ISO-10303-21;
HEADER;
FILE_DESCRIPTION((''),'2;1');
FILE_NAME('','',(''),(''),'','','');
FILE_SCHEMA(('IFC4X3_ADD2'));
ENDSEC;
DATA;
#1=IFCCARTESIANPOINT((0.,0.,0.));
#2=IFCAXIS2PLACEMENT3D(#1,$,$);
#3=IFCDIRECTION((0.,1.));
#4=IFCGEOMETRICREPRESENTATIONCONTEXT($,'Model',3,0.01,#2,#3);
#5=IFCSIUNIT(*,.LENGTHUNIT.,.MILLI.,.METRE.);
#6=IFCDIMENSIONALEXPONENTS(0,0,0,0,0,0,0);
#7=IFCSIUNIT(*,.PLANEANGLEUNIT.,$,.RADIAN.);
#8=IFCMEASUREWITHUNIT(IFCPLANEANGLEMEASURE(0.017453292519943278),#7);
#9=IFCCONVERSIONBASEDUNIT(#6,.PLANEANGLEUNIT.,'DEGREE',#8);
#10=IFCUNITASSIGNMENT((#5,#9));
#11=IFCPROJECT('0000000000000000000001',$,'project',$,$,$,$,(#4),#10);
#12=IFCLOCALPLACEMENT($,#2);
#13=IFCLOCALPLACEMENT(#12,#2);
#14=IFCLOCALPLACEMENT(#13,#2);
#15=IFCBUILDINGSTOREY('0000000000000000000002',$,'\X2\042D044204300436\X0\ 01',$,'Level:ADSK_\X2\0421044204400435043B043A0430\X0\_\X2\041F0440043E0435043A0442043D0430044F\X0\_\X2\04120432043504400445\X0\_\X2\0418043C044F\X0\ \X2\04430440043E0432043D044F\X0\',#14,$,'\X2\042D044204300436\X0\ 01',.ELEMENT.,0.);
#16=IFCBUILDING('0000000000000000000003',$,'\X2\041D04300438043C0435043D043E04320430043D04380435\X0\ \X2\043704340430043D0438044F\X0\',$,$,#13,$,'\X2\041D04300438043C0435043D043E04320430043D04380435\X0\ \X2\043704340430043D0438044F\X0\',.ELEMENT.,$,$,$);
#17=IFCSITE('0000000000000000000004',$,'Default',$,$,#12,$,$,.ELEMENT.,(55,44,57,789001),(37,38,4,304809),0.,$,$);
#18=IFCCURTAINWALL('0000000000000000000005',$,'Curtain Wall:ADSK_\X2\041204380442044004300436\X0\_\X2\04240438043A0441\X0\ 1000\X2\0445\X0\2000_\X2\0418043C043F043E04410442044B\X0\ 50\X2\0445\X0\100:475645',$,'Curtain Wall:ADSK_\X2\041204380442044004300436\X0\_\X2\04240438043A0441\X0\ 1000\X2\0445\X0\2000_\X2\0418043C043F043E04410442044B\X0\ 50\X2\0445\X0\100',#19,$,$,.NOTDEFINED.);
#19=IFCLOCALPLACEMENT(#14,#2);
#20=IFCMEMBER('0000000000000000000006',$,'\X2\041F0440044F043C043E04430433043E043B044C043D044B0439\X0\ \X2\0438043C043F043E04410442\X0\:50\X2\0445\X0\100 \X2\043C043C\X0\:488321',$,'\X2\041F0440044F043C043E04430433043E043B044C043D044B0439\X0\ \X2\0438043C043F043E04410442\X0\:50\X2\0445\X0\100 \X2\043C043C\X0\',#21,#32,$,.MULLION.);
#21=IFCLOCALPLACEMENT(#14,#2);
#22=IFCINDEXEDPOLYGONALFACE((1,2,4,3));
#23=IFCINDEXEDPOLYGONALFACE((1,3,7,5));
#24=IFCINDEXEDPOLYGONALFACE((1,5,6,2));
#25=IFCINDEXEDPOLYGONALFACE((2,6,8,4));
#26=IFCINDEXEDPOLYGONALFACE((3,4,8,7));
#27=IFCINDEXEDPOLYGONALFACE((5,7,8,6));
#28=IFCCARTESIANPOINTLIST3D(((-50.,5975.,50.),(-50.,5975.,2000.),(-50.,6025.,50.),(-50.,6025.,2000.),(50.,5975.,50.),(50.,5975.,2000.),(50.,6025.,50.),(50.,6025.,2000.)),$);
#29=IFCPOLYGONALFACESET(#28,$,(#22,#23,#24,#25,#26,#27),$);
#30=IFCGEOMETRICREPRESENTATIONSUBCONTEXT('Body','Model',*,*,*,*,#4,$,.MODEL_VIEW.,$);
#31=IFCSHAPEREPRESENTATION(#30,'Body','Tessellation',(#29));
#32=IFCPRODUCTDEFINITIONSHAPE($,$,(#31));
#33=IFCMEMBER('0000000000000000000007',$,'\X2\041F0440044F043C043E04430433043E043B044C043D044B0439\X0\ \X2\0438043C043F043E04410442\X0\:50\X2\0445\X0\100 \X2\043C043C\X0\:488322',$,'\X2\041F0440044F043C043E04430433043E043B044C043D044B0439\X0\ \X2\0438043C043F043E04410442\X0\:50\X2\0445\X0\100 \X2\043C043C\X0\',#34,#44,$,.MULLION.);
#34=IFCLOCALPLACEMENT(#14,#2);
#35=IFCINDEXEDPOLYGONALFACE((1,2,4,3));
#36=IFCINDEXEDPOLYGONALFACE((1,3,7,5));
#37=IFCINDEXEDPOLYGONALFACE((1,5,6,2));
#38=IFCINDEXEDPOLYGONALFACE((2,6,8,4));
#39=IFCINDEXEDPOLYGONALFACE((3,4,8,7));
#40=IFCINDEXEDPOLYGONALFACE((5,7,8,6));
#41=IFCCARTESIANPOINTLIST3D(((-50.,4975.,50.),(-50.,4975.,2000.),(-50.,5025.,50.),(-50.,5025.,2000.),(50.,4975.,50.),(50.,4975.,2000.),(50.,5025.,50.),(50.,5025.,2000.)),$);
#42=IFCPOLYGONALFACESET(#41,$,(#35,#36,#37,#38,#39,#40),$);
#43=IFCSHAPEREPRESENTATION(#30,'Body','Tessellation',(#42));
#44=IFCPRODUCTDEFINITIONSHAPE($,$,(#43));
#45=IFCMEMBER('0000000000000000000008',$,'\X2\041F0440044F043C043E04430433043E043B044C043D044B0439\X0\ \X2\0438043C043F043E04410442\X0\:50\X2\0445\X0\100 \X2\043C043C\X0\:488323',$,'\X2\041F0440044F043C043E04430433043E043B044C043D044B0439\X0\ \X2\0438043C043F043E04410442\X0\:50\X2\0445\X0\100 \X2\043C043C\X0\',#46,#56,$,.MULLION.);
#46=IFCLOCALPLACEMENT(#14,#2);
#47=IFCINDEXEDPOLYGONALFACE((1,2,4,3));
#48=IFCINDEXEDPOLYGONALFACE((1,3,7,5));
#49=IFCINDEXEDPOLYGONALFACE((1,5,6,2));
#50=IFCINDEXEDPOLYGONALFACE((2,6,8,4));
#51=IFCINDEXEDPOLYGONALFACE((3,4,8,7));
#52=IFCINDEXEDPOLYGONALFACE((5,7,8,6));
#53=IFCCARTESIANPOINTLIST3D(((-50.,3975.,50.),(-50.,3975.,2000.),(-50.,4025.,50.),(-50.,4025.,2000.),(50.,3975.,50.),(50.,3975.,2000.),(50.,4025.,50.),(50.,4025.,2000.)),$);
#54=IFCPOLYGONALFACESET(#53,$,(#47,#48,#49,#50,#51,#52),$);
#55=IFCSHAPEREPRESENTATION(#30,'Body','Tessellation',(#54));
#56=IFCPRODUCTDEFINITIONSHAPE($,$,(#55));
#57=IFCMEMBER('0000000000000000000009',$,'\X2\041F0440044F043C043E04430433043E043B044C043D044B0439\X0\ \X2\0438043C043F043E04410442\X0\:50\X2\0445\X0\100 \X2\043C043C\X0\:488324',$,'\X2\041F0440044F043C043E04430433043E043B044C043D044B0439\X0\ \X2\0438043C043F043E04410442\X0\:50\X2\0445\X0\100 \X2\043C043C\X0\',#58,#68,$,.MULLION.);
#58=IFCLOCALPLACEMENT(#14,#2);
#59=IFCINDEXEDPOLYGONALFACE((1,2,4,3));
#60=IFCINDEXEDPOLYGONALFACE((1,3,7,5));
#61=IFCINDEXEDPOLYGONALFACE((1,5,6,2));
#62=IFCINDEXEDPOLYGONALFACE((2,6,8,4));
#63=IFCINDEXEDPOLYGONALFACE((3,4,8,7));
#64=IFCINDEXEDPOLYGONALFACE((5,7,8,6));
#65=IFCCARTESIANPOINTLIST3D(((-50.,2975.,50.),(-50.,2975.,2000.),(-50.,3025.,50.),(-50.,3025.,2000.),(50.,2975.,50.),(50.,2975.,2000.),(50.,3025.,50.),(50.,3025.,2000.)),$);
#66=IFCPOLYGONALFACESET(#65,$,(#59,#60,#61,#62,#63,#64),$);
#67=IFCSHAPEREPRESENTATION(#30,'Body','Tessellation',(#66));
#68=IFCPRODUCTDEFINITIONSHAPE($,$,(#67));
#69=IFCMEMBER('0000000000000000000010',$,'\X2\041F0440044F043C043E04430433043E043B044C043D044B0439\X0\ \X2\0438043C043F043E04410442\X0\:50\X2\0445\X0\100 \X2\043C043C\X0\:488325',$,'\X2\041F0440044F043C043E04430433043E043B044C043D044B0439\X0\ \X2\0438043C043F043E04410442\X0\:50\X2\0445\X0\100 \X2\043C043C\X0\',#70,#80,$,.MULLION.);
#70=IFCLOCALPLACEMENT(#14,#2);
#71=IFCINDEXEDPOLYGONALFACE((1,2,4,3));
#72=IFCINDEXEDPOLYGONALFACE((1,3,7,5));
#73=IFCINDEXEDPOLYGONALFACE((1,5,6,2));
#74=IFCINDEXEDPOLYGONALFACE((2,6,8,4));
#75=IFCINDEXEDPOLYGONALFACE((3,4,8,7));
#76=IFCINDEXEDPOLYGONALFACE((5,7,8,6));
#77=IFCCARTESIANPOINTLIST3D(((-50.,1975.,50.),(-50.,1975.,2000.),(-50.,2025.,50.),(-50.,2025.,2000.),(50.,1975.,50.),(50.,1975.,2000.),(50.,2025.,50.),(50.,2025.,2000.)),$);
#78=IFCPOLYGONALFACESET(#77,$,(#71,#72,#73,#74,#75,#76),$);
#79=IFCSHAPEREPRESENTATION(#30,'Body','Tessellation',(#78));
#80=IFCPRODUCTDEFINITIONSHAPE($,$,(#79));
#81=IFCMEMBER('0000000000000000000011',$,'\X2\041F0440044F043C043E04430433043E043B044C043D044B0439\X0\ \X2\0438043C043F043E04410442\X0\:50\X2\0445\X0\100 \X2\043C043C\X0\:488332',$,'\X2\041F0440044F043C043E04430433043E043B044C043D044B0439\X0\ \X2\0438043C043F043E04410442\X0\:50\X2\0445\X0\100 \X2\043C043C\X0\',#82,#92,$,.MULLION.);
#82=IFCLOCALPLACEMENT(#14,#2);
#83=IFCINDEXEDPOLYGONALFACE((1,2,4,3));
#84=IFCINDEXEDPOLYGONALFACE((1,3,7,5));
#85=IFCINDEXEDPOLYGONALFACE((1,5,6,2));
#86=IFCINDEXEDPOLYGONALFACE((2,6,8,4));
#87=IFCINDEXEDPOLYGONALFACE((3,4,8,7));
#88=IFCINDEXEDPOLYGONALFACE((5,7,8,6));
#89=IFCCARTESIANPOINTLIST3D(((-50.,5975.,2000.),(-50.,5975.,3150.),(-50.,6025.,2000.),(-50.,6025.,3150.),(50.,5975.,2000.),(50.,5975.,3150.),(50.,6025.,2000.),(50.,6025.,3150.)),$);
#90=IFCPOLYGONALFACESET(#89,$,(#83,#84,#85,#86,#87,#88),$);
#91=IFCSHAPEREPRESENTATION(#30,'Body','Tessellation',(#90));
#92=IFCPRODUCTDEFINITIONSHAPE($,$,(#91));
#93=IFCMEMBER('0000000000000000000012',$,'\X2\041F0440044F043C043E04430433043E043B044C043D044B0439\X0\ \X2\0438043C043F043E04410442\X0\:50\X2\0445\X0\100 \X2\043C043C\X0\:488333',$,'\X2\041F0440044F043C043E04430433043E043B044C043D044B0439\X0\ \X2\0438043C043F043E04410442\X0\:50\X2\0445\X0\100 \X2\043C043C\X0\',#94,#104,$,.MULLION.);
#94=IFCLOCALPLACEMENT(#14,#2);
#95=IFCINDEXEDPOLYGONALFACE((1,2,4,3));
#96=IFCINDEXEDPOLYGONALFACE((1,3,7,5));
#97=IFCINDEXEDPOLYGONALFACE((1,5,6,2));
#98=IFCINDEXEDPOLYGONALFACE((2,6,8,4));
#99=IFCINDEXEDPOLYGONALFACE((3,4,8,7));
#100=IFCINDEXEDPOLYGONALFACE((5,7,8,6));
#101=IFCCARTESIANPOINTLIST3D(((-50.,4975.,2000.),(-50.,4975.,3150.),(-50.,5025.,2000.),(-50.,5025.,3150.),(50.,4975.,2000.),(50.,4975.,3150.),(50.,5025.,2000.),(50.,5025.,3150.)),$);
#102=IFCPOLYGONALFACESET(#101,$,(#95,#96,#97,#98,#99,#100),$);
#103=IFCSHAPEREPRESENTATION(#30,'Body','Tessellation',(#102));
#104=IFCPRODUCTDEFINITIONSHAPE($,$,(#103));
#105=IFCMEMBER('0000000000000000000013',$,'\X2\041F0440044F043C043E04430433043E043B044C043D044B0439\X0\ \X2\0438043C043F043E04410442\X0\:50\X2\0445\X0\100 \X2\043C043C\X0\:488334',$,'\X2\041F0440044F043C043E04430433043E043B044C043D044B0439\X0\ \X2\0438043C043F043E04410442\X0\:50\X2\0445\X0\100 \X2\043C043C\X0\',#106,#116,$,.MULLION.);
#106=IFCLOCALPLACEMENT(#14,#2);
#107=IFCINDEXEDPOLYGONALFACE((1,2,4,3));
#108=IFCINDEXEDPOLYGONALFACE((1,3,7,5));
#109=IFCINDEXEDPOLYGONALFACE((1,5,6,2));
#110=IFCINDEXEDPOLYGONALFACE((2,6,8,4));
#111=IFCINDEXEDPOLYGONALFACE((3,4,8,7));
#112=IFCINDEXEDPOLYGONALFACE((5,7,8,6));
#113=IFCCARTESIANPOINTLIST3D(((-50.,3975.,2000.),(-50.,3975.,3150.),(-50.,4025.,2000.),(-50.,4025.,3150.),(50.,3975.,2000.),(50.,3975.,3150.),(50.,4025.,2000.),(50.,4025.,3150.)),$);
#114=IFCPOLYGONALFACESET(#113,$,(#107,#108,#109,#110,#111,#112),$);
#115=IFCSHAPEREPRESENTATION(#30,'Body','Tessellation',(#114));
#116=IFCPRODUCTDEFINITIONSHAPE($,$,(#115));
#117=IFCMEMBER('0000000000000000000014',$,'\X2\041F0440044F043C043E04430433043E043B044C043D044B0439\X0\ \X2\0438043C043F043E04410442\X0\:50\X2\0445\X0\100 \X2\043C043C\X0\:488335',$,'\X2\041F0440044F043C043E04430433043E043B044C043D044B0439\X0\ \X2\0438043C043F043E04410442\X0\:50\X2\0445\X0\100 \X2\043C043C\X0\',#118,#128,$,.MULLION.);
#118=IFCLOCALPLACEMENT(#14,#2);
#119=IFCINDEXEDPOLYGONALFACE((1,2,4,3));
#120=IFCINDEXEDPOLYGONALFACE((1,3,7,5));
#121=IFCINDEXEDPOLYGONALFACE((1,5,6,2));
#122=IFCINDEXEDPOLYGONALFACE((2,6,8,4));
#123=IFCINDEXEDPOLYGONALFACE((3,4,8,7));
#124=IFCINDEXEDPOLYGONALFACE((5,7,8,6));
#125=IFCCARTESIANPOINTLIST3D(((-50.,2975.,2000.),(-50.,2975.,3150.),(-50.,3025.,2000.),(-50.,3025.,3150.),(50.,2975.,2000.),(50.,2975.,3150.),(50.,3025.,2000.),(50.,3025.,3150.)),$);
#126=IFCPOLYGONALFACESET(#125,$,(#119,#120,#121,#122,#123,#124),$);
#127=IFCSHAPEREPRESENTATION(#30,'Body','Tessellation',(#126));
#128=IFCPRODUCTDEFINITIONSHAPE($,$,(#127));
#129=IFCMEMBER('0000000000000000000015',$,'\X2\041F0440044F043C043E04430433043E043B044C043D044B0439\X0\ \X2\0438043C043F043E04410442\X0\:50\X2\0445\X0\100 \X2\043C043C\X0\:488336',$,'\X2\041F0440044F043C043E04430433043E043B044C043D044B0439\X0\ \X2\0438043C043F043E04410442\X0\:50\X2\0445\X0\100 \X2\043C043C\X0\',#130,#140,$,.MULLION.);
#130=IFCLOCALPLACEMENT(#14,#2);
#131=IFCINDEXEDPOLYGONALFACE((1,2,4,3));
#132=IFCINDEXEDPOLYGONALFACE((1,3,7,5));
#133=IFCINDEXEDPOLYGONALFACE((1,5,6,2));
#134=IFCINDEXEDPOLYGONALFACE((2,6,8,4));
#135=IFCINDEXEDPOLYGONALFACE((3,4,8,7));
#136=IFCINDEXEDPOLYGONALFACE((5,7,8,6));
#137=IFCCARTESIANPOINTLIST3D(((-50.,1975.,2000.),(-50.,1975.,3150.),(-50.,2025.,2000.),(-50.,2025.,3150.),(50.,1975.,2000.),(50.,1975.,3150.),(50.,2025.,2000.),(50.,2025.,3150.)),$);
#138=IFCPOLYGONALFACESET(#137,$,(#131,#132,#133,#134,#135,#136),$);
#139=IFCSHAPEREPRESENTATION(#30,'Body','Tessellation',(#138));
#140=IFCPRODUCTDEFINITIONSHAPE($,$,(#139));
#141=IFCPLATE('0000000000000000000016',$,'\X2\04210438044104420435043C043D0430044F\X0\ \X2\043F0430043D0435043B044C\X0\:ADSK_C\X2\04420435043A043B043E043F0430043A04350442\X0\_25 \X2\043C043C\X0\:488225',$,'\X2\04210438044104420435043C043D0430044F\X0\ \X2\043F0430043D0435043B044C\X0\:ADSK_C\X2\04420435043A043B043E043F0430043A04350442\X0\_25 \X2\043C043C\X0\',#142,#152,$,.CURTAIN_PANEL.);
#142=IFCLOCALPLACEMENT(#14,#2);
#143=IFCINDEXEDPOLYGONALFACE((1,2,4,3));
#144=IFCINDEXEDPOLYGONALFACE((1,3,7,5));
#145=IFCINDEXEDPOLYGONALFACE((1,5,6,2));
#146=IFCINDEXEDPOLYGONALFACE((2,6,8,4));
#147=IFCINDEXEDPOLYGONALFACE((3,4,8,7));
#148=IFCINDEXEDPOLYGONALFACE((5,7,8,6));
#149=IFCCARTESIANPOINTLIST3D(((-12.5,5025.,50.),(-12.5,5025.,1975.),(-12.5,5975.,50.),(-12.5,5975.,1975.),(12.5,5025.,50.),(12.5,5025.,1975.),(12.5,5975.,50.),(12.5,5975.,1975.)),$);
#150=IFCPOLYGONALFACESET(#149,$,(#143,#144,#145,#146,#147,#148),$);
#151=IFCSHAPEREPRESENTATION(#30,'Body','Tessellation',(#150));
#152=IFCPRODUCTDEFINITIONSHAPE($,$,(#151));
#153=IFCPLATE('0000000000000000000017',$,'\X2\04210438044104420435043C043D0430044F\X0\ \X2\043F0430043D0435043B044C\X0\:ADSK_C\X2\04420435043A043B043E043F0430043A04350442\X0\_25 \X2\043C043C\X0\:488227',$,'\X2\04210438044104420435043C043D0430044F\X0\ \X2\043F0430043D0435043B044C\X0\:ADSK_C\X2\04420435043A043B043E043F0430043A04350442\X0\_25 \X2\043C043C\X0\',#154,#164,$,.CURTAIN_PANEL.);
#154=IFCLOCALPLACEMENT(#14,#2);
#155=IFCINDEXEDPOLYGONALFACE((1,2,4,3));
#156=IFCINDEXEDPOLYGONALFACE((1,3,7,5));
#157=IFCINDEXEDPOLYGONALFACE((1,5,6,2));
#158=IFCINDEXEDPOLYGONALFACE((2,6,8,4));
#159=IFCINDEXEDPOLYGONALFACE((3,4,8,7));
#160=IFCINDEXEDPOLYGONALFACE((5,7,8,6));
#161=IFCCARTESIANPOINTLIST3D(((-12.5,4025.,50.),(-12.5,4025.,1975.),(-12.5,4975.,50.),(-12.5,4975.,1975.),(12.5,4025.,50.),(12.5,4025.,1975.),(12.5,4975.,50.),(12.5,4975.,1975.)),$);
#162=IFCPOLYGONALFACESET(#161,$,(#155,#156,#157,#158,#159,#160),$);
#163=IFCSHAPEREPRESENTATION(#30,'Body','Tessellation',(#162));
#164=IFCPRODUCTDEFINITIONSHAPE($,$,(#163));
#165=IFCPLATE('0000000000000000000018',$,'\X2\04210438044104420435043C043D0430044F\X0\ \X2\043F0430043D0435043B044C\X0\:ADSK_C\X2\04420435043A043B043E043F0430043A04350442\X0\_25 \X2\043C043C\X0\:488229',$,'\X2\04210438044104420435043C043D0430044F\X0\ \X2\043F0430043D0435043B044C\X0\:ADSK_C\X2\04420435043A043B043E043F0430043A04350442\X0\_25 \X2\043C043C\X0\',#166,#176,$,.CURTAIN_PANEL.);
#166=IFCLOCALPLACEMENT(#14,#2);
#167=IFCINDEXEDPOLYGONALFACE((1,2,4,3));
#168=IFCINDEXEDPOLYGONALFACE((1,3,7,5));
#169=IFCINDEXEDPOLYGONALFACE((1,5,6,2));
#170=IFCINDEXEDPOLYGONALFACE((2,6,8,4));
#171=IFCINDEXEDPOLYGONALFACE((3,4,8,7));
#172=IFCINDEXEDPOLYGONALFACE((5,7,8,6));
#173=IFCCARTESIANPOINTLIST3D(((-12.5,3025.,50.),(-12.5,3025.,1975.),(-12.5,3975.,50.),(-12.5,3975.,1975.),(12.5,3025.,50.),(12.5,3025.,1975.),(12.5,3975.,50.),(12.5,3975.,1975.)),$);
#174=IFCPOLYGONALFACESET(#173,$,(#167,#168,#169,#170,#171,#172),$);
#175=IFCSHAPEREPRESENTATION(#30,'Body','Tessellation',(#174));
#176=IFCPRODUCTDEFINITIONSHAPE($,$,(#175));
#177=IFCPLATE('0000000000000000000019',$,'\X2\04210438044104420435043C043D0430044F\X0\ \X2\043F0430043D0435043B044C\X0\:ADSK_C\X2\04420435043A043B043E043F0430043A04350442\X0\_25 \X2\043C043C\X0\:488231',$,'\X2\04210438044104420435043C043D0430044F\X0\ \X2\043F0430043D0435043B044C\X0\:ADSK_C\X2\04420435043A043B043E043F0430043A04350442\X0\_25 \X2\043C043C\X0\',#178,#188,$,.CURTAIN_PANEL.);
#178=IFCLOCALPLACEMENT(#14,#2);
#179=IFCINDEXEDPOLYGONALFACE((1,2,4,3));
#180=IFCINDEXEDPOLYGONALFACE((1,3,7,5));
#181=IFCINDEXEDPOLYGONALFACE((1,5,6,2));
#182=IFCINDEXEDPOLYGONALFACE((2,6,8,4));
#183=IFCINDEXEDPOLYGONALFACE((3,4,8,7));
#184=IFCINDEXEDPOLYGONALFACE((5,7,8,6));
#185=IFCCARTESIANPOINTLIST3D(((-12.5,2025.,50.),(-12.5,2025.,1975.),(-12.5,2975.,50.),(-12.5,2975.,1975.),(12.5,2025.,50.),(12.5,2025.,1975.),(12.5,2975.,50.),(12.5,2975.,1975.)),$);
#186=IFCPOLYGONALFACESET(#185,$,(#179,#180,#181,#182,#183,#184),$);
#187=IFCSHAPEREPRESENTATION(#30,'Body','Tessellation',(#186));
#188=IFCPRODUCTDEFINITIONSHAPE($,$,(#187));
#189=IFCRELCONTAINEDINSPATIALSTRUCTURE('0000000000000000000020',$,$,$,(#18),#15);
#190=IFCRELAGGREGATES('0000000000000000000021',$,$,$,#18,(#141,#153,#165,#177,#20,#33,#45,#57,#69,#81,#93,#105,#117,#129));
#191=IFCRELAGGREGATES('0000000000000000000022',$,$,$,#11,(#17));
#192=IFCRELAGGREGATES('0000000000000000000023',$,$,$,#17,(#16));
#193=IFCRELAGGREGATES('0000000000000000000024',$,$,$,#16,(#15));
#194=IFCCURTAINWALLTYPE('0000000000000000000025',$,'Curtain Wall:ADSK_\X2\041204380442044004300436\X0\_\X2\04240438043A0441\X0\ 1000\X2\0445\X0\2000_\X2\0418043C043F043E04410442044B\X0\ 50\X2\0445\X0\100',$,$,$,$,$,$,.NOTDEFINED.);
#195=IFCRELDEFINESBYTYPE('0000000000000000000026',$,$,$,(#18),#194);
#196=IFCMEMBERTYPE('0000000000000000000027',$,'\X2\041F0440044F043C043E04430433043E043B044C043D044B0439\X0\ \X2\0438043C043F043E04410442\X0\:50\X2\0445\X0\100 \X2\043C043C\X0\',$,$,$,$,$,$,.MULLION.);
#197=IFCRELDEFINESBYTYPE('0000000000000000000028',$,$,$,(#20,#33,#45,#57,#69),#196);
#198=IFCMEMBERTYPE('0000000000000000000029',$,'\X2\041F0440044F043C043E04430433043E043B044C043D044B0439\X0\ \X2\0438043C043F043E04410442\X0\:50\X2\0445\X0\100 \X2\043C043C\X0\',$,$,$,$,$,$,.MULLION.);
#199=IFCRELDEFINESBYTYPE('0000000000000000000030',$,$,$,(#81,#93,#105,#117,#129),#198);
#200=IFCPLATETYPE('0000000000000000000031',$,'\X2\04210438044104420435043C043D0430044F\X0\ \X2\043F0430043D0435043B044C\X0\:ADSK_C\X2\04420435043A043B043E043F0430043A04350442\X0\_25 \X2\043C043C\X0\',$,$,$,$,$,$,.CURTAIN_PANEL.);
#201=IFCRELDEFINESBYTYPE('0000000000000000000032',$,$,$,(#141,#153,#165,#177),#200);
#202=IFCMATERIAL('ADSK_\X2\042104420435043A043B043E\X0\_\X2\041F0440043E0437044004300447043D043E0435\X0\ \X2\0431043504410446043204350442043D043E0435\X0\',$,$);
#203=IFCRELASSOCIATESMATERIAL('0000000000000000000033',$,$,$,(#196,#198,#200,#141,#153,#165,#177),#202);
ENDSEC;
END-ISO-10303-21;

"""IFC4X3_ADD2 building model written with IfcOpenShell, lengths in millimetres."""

from ifc_helpers import new_model, entity, si_unit, converted_unit, direction, frame, frame_2d, origin, origin_2d_with_axis, place, context, subcontext, project, spatial, rectangle, extrude, source, transform, mapped, material, material_profile, profile_set, type_object, type_shapes, element, aggregate, save


model = new_model("IFC4X3_ADD2")

# Units and contexts
model_context = context("Model", 3, precision=0.01, world=origin(), true_north=direction((0.0, 1.0)))
body_context = subcontext(model_context, "Body", "Model", "MODEL_VIEW")
ifc_project = project(units=[si_unit("LENGTHUNIT", "METRE", prefix="MILLI"), converted_unit("PLANEANGLEUNIT", "DEGREE", entity("IfcPlaneAngleMeasure", 0.017453292519943278), si_unit("PLANEANGLEUNIT", "RADIAN"), dimensions=[0, 0, 0, 0, 0, 0, 0])], contexts=[model_context])

# Site, building, storey
site_placement = place(None, origin())
site = spatial("IfcSite", under=ifc_project, at=site_placement, Name="Default", CompositionType="ELEMENT", RefLatitude=(55, 44, 57, 789001), RefLongitude=(37, 38, 4, 304809), RefElevation=0.0)
building_placement = place(site_placement, origin())
building = spatial("IfcBuilding", under=site, at=building_placement, Name="Наименование здания", LongName="Наименование здания", CompositionType="ELEMENT")
storey_placement = place(building_placement, origin())
storey = spatial("IfcBuildingStorey", under=building, at=storey_placement, Name="Этаж 01", ObjectType="Level:ADSK_Стрелка_Проектная_Вверх_Имя уровня", LongName="Этаж 01", CompositionType="ELEMENT", Elevation=0.0)

# Curtain wall, members, plates
curtain_wall_type = type_object("IfcCurtainWallType", Name="Curtain Wall:ADSK_Витраж_Фикс 1000х2000_Импосты 50х100", PredefinedType="NOTDEFINED")
curtain_wall_placement = place(storey_placement, origin())
curtain_wall = element("IfcCurtainWall", 1, at=curtain_wall_placement, inside=storey, type_object=curtain_wall_type, Name="Curtain Wall:ADSK_Витраж_Фикс 1000х2000_Импосты 50х100:475645", ObjectType="Curtain Wall:ADSK_Витраж_Фикс 1000х2000_Импосты 50х100", PredefinedType="NOTDEFINED")
ifc_material = material(Name="ADSK_Стекло_Прозрачное бесцветное")
ifc_material_profile = material_profile(ifc_material, rectangle(XDim=50.0, YDim=100.0, at=frame_2d((0.0, 0.0), x_axis=(1.0, 0.0))), Name="50х100 мм")
ifc_profile_set = profile_set([ifc_material_profile], Name="50х100 мм")
member_type_1 = type_object("IfcMemberType", Name="Прямоугольный импост:50х100 мм", PredefinedType="MULLION", material=ifc_profile_set)
shared_shape_1 = source(origin(), body_context, "Body", "SweptSolid", [
    extrude(rectangle(XDim=50.0, YDim=100.0, at=frame_2d((0.0, 0.0), x_axis=(1.0, 0.0))), frame((0.0, 0.0, -1950.0), z_axis=(0.0, 0.0, 1.0), x_axis=(-1.0, 0.0, 0.0)), (0.0, 0.0, 1.0), 1950.0),
])
type_shapes(member_type_1, [shared_shape_1])
member_1_placement = place(curtain_wall_placement, frame((0.0, 6000.0, 50.0), z_axis=(0.0, 0.0, -1.0), x_axis=(0.0, -1.0, 0.0)))
member_1 = element("IfcMember", 2, at=member_1_placement, type_object=member_type_1, Name="Прямоугольный импост:50х100 мм:488321", ObjectType="Прямоугольный импост:50х100 мм", PredefinedType="MULLION", context=body_context, shape_type="MappedRepresentation", body=[
    mapped(shared_shape_1, transform((0.0, 0.0, 0.0), scale=1.0)),
])
member_2_placement = place(curtain_wall_placement, frame((0.0, 5000.0, 50.0), z_axis=(0.0, 0.0, -1.0), x_axis=(0.0, -1.0, 0.0)))
member_2 = element("IfcMember", 3, at=member_2_placement, type_object=member_type_1, Name="Прямоугольный импост:50х100 мм:488322", ObjectType="Прямоугольный импост:50х100 мм", PredefinedType="MULLION", context=body_context, shape_type="MappedRepresentation", body=[
    mapped(shared_shape_1, transform((0.0, 0.0, 0.0), scale=1.0)),
])
member_3_placement = place(curtain_wall_placement, frame((0.0, 4000.0, 50.0), z_axis=(0.0, 0.0, -1.0), x_axis=(0.0, -1.0, 0.0)))
member_3 = element("IfcMember", 4, at=member_3_placement, type_object=member_type_1, Name="Прямоугольный импост:50х100 мм:488323", ObjectType="Прямоугольный импост:50х100 мм", PredefinedType="MULLION", context=body_context, shape_type="MappedRepresentation", body=[
    mapped(shared_shape_1, transform((0.0, 0.0, 0.0), scale=1.0)),
])
member_4_placement = place(curtain_wall_placement, frame((0.0, 3000.0, 50.0), z_axis=(0.0, 0.0, -1.0), x_axis=(0.0, -1.0, 0.0)))
member_4 = element("IfcMember", 5, at=member_4_placement, type_object=member_type_1, Name="Прямоугольный импост:50х100 мм:488324", ObjectType="Прямоугольный импост:50х100 мм", PredefinedType="MULLION", context=body_context, shape_type="MappedRepresentation", body=[
    mapped(shared_shape_1, transform((0.0, 0.0, 0.0), scale=1.0)),
])
member_5_placement = place(curtain_wall_placement, frame((0.0, 2000.0, 50.0), z_axis=(0.0, 0.0, -1.0), x_axis=(0.0, -1.0, 0.0)))
member_5 = element("IfcMember", 6, at=member_5_placement, type_object=member_type_1, Name="Прямоугольный импост:50х100 мм:488325", ObjectType="Прямоугольный импост:50х100 мм", PredefinedType="MULLION", context=body_context, shape_type="MappedRepresentation", body=[
    mapped(shared_shape_1, transform((0.0, 0.0, 0.0), scale=1.0)),
])
member_type_2 = type_object("IfcMemberType", Name="Прямоугольный импост:50х100 мм", PredefinedType="MULLION", material=ifc_profile_set)
shared_shape_2 = source(origin(), body_context, "Body", "SweptSolid", [
    extrude(rectangle(XDim=50.0, YDim=100.0, at=frame_2d((0.0, 0.0), x_axis=(1.0, 0.0))), frame((0.0, 0.0, -1150.0), z_axis=(0.0, 0.0, 1.0), x_axis=(-1.0, 0.0, 0.0)), (0.0, 0.0, 1.0), 1150.0),
])
type_shapes(member_type_2, [shared_shape_2])
member_6_placement = place(curtain_wall_placement, frame((0.0, 6000.0, 2000.0), z_axis=(0.0, 0.0, -1.0), x_axis=(0.0, -1.0, 0.0)))
member_6 = element("IfcMember", 7, at=member_6_placement, type_object=member_type_2, Name="Прямоугольный импост:50х100 мм:488332", ObjectType="Прямоугольный импост:50х100 мм", PredefinedType="MULLION", context=body_context, shape_type="MappedRepresentation", body=[
    mapped(shared_shape_2, transform((0.0, 0.0, 0.0), scale=1.0)),
])
member_7_placement = place(curtain_wall_placement, frame((0.0, 5000.0, 2000.0), z_axis=(0.0, 0.0, -1.0), x_axis=(0.0, -1.0, 0.0)))
member_7 = element("IfcMember", 8, at=member_7_placement, type_object=member_type_2, Name="Прямоугольный импост:50х100 мм:488333", ObjectType="Прямоугольный импост:50х100 мм", PredefinedType="MULLION", context=body_context, shape_type="MappedRepresentation", body=[
    mapped(shared_shape_2, transform((0.0, 0.0, 0.0), scale=1.0)),
])
member_8_placement = place(curtain_wall_placement, frame((0.0, 4000.0, 2000.0), z_axis=(0.0, 0.0, -1.0), x_axis=(0.0, -1.0, 0.0)))
member_8 = element("IfcMember", 9, at=member_8_placement, type_object=member_type_2, Name="Прямоугольный импост:50х100 мм:488334", ObjectType="Прямоугольный импост:50х100 мм", PredefinedType="MULLION", context=body_context, shape_type="MappedRepresentation", body=[
    mapped(shared_shape_2, transform((0.0, 0.0, 0.0), scale=1.0)),
])
member_9_placement = place(curtain_wall_placement, frame((0.0, 3000.0, 2000.0), z_axis=(0.0, 0.0, -1.0), x_axis=(0.0, -1.0, 0.0)))
member_9 = element("IfcMember", 10, at=member_9_placement, type_object=member_type_2, Name="Прямоугольный импост:50х100 мм:488335", ObjectType="Прямоугольный импост:50х100 мм", PredefinedType="MULLION", context=body_context, shape_type="MappedRepresentation", body=[
    mapped(shared_shape_2, transform((0.0, 0.0, 0.0), scale=1.0)),
])
member_10_placement = place(curtain_wall_placement, frame((0.0, 2000.0, 2000.0), z_axis=(0.0, 0.0, -1.0), x_axis=(0.0, -1.0, 0.0)))
member_10 = element("IfcMember", 11, at=member_10_placement, type_object=member_type_2, Name="Прямоугольный импост:50х100 мм:488336", ObjectType="Прямоугольный импост:50х100 мм", PredefinedType="MULLION", context=body_context, shape_type="MappedRepresentation", body=[
    mapped(shared_shape_2, transform((0.0, 0.0, 0.0), scale=1.0)),
])
plate_type_1 = type_object("IfcPlateType", Name="Системная панель:ADSK_Cтеклопакет_25 мм", PredefinedType="CURTAIN_PANEL", material=ifc_material)
shared_shape_3 = source(origin(), body_context, "Body", "SweptSolid", [
    extrude(rectangle(XDim=25.0, YDim=950.0, at=origin_2d_with_axis()), frame((0.0, 0.0, 0.0), z_axis=(0.0, 0.0, 1.0), x_axis=(0.0, 1.0, 0.0)), (0.0, 0.0, 1.0), 1925.0),
])
type_shapes(plate_type_1, [shared_shape_3])
plate_1_placement = place(curtain_wall_placement, frame((0.0, 5500.0, 50.0), z_axis=(0.0, 0.0, 1.0), x_axis=(0.0, -1.0, 0.0)))
plate_1 = element("IfcPlate", 12, at=plate_1_placement, type_object=plate_type_1, material=ifc_material, Name="Системная панель:ADSK_Cтеклопакет_25 мм:488225", ObjectType="Системная панель:ADSK_Cтеклопакет_25 мм", PredefinedType="CURTAIN_PANEL", context=body_context, shape_type="MappedRepresentation", body=[
    mapped(shared_shape_3, transform((0.0, 0.0, 0.0), scale=1.0)),
])
plate_2_placement = place(curtain_wall_placement, frame((0.0, 4500.0, 50.0), z_axis=(0.0, 0.0, 1.0), x_axis=(0.0, -1.0, 0.0)))
plate_2 = element("IfcPlate", 13, at=plate_2_placement, type_object=plate_type_1, material=ifc_material, Name="Системная панель:ADSK_Cтеклопакет_25 мм:488227", ObjectType="Системная панель:ADSK_Cтеклопакет_25 мм", PredefinedType="CURTAIN_PANEL", context=body_context, shape_type="MappedRepresentation", body=[
    mapped(shared_shape_3, transform((0.0, 0.0, 0.0), scale=1.0)),
])
plate_3_placement = place(curtain_wall_placement, frame((0.0, 3500.0, 50.0), z_axis=(0.0, 0.0, 1.0), x_axis=(0.0, -1.0, 0.0)))
plate_3 = element("IfcPlate", 14, at=plate_3_placement, type_object=plate_type_1, material=ifc_material, Name="Системная панель:ADSK_Cтеклопакет_25 мм:488229", ObjectType="Системная панель:ADSK_Cтеклопакет_25 мм", PredefinedType="CURTAIN_PANEL", context=body_context, shape_type="MappedRepresentation", body=[
    mapped(shared_shape_3, transform((0.0, 0.0, 0.0), scale=1.0)),
])
plate_4_placement = place(curtain_wall_placement, frame((0.0, 2500.0, 50.0), z_axis=(0.0, 0.0, 1.0), x_axis=(0.0, -1.0, 0.0)))
plate_4 = element("IfcPlate", 15, at=plate_4_placement, type_object=plate_type_1, material=ifc_material, Name="Системная панель:ADSK_Cтеклопакет_25 мм:488231", ObjectType="Системная панель:ADSK_Cтеклопакет_25 мм", PredefinedType="CURTAIN_PANEL", context=body_context, shape_type="MappedRepresentation", body=[
    mapped(shared_shape_3, transform((0.0, 0.0, 0.0), scale=1.0)),
])
aggregate(curtain_wall, [plate_1, plate_2, plate_3, plate_4, member_1, member_2, member_3, member_4, member_5, member_6, member_7, member_8, member_9, member_10])

save(model, "model.ifc")
